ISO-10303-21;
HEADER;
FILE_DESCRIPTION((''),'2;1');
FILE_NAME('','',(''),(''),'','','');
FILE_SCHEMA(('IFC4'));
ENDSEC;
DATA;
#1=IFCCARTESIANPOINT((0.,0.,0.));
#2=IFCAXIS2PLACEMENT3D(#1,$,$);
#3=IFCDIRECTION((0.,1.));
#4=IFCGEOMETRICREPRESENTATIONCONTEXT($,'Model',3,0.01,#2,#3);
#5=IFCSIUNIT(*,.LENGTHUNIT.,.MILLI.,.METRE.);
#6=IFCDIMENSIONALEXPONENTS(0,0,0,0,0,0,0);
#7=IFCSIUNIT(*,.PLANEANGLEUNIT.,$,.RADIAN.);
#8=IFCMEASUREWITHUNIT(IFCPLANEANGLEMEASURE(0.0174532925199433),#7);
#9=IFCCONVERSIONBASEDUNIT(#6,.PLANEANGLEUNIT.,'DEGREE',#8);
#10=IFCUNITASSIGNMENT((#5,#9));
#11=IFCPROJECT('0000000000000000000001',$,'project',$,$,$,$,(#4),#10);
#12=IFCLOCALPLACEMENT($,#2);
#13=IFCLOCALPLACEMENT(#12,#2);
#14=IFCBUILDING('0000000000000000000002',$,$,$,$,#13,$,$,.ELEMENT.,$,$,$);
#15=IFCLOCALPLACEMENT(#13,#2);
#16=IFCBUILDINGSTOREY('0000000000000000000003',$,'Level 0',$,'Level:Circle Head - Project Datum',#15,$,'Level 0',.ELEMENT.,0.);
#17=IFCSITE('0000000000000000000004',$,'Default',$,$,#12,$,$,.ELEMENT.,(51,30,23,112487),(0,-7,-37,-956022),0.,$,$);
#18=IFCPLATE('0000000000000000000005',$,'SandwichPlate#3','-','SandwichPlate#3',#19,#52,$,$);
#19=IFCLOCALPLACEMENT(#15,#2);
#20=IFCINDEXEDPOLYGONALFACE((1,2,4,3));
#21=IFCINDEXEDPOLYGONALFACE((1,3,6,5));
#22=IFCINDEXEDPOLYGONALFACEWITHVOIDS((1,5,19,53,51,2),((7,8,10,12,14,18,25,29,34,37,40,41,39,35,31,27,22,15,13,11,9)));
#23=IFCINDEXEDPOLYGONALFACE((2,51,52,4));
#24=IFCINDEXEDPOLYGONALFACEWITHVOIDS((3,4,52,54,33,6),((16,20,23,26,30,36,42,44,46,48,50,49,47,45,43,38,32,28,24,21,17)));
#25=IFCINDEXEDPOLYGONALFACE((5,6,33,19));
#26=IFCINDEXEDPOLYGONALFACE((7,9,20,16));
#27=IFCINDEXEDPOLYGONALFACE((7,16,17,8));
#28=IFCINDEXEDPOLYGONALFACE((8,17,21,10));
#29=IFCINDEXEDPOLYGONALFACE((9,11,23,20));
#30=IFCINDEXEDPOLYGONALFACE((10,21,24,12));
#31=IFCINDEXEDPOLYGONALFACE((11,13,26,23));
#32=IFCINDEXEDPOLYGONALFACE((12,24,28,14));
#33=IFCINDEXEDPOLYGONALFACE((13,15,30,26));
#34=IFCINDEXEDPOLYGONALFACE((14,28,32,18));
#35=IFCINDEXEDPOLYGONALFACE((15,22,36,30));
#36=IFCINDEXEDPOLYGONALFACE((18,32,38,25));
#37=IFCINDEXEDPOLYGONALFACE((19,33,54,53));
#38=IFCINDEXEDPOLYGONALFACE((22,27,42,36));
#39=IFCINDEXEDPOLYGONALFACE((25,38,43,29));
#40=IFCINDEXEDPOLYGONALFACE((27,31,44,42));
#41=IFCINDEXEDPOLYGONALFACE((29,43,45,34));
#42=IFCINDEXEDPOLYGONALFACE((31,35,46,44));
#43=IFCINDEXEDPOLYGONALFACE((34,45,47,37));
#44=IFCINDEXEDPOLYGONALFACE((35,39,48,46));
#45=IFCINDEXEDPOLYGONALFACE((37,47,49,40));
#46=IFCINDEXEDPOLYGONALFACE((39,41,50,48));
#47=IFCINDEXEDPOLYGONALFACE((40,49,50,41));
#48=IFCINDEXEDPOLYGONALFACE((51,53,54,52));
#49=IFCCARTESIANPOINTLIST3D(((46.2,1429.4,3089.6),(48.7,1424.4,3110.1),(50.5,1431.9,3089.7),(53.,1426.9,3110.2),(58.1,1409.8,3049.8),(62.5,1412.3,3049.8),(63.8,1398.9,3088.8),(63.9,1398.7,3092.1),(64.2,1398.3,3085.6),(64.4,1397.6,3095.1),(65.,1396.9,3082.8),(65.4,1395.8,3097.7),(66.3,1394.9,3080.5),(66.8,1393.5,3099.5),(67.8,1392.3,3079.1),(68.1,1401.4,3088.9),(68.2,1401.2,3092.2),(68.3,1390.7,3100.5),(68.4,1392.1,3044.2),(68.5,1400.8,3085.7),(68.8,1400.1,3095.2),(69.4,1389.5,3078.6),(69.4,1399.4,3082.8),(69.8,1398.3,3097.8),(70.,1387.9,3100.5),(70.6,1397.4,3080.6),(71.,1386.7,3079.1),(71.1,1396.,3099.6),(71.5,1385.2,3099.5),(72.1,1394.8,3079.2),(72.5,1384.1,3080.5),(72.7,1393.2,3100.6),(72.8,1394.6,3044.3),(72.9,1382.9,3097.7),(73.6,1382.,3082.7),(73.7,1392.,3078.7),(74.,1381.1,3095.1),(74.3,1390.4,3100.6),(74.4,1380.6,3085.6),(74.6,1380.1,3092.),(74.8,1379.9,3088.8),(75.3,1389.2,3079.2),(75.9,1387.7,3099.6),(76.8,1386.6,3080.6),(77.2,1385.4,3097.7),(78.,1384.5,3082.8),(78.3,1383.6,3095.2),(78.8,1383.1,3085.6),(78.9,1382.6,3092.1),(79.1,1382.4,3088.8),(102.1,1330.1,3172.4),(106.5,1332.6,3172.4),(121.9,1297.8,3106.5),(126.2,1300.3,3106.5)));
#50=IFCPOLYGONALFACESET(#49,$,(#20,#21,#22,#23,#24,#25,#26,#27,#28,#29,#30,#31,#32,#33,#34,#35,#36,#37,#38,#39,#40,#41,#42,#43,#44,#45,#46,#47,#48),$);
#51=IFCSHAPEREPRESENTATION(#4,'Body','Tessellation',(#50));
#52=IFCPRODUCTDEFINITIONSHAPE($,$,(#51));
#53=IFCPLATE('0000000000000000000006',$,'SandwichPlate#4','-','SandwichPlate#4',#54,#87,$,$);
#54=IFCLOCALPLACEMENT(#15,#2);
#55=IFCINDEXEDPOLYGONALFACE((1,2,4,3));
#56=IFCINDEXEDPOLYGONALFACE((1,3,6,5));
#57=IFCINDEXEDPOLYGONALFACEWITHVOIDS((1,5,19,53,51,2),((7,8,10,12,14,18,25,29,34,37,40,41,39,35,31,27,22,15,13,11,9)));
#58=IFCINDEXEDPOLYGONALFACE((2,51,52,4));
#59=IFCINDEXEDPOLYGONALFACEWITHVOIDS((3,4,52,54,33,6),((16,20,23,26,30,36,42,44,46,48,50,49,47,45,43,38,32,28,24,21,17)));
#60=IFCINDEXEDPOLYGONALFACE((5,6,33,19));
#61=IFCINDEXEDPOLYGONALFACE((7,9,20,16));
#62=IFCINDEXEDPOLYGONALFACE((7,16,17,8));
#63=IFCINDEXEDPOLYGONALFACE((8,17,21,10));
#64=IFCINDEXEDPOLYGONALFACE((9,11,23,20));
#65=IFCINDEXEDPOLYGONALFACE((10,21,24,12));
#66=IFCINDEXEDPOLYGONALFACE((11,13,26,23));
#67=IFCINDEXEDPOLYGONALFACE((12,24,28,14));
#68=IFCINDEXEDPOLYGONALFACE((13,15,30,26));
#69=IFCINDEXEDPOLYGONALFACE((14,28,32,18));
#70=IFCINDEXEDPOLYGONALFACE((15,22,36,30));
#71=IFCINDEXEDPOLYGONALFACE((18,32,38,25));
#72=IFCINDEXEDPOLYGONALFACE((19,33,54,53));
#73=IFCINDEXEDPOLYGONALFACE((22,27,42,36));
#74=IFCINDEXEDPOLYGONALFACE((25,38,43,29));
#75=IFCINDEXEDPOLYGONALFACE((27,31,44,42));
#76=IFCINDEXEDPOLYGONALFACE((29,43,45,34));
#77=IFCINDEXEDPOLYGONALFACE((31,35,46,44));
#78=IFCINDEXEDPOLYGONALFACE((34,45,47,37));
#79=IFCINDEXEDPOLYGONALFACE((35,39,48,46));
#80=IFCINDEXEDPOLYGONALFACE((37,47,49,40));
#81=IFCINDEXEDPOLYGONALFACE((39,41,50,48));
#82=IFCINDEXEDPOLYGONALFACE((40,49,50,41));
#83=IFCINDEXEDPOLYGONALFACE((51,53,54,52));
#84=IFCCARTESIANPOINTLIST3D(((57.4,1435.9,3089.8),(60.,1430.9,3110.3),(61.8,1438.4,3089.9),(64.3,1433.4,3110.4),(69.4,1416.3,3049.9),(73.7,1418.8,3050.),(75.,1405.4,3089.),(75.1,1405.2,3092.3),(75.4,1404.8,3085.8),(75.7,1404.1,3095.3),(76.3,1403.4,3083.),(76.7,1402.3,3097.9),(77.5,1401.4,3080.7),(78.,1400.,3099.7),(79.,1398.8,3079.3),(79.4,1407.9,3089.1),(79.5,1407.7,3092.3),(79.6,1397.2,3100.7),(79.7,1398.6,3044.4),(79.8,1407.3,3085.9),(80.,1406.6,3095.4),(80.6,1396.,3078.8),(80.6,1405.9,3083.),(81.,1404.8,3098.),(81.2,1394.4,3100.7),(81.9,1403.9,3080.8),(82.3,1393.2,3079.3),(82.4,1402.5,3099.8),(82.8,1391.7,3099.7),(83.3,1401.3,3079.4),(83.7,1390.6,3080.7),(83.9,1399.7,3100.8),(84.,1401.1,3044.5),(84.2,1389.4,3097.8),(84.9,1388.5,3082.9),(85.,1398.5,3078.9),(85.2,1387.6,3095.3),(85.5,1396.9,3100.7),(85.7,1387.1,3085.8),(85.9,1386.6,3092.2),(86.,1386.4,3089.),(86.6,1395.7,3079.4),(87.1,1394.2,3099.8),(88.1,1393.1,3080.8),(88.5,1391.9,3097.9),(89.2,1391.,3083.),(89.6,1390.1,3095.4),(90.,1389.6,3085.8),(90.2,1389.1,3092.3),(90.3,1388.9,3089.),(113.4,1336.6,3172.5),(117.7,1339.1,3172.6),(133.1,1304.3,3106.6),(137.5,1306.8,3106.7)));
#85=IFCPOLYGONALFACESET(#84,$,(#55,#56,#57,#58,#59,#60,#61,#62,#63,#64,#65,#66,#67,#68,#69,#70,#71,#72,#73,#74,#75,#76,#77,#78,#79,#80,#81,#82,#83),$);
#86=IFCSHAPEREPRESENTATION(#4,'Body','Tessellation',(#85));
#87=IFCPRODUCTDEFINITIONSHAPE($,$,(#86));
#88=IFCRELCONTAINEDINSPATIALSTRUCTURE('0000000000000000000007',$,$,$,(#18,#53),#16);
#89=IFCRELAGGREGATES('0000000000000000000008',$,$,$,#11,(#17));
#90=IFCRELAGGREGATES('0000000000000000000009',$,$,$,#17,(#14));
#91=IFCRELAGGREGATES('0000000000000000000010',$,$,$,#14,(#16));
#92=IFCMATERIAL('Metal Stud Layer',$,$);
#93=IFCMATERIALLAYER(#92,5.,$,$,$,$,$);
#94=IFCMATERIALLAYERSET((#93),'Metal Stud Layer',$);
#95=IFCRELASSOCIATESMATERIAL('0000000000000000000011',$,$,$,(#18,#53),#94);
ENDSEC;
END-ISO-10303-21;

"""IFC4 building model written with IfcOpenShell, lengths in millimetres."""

from ifc_helpers import new_model, entity, si_unit, converted_unit, direction, frame, origin, origin_with_axes, origin_2d_with_axis, place, context, project, spatial, polyline, circle, outline, extrude, material, layer, layer_set, element, save


model = new_model("IFC4")

# Units and contexts
model_context = context("Model", 3, precision=0.01, world=origin(), true_north=direction((0.0, 1.0)))
ifc_project = project(units=[si_unit("LENGTHUNIT", "METRE", prefix="MILLI"), converted_unit("PLANEANGLEUNIT", "DEGREE", entity("IfcPlaneAngleMeasure", 0.0174532925199433), si_unit("PLANEANGLEUNIT", "RADIAN"), dimensions=[0, 0, 0, 0, 0, 0, 0])], contexts=[model_context])

# Site, building, storey
site_placement = place(None, origin())
site = spatial("IfcSite", under=ifc_project, at=site_placement, Name="Default", CompositionType="ELEMENT", RefLatitude=(51, 30, 23, 112487), RefLongitude=(0, -7, -37, -956022), RefElevation=0.0)
building_placement = place(site_placement, origin())
building = spatial("IfcBuilding", under=site, at=building_placement, CompositionType="ELEMENT")
storey_placement = place(building_placement, origin())
storey = spatial("IfcBuildingStorey", under=building, at=storey_placement, Name="Level 0", ObjectType="Level:Circle Head - Project Datum", LongName="Level 0", CompositionType="ELEMENT", Elevation=0.0)

# Plates, openings
ifc_material_1 = material(Name="Metal Stud Layer")
ifc_layer_1 = layer(ifc_material_1, 5.0)
ifc_layer_set_1 = layer_set([ifc_layer_1], Name="Metal Stud Layer")
plate_1_placement = place(storey_placement, frame((62.0, 1403.5, 3036.7), z_axis=(0.865935, 0.499948, 0.014432), x_axis=(-0.259821, 0.424992, 0.867107)))
plate_1 = element("IfcPlate", 1, at=plate_1_placement, inside=storey, material=ifc_layer_set_1, Name="SandwichPlate#3", Description="-", ObjectType="SandwichPlate#3", context=model_context, shape_type="SweptSolid", body=[
    extrude(outline(polyline([(0.0, 0.0), (76.0, 0.0), (76.0, 140.0), (0.0, 140.0), (0.0, 0.0)])), origin_with_axes(), (0.0, 0.0, 1.0), 5.0),
])
opening_1_placement = place(plate_1_placement, frame((0.0, 0.0, 0.0), z_axis=(0.0, 0.0, 1.0), x_axis=(1.0, 0.0, 0.0)))
element("IfcOpeningElement", 2, at=opening_1_placement, cuts=plate_1, ObjectType="Opening", context=model_context, shape_type="SweptSolid", body=[
    extrude(outline(polyline([(0.0, 0.0), (15.0, 0.0), (0.0, 15.0), (0.0, 0.0)])), origin(), (0.0, 0.0, 1.0), 5.0),
])
opening_2_placement = place(plate_1_placement, frame((0.0, 0.0, 0.0), z_axis=(0.0, 0.0, 1.0), x_axis=(1.0, 0.0, 0.0)))
element("IfcOpeningElement", 3, at=opening_2_placement, cuts=plate_1, ObjectType="Opening", context=model_context, shape_type="SweptSolid", body=[
    extrude(outline(polyline([(76.0, 0.0), (76.0, 15.0), (61.0, 0.0), (76.0, 0.0)])), origin(), (0.0, 0.0, 1.0), 5.0),
])
opening_3_placement = place(plate_1_placement, frame((38.0, 40.0, -0.5), z_axis=(0.0, 0.0, 1.0), x_axis=(0.0, 1.0, 0.0)))
element("IfcOpeningElement", 4, at=opening_3_placement, cuts=plate_1, ObjectType="Opening", context=model_context, shape_type="SweptSolid", body=[
    extrude(circle(Radius=11.0, at=origin_2d_with_axis()), origin(), (0.0, 0.0, 1.0), 6.0),
])
plate_2_placement = place(storey_placement, frame((73.3, 1410.0, 3036.9), z_axis=(0.865935, 0.499948, 0.014432), x_axis=(-0.259821, 0.424992, 0.867107)))
plate_2 = element("IfcPlate", 5, at=plate_2_placement, inside=storey, material=ifc_layer_set_1, Name="SandwichPlate#4", Description="-", ObjectType="SandwichPlate#4", context=model_context, shape_type="SweptSolid", body=[
    extrude(outline(polyline([(0.0, 0.0), (76.0, 0.0), (76.0, 140.0), (0.0, 140.0), (0.0, 0.0)])), origin_with_axes(), (0.0, 0.0, 1.0), 5.0),
])
opening_4_placement = place(plate_2_placement, frame((0.0, 0.0, 0.0), z_axis=(0.0, 0.0, 1.0), x_axis=(1.0, 0.0, 0.0)))
element("IfcOpeningElement", 6, at=opening_4_placement, cuts=plate_2, ObjectType="Opening", context=model_context, shape_type="SweptSolid", body=[
    extrude(outline(polyline([(0.0, 0.0), (15.0, 0.0), (0.0, 15.0), (0.0, 0.0)])), origin(), (0.0, 0.0, 1.0), 5.0),
])
opening_5_placement = place(plate_2_placement, frame((0.0, 0.0, 0.0), z_axis=(0.0, 0.0, 1.0), x_axis=(1.0, 0.0, 0.0)))
element("IfcOpeningElement", 7, at=opening_5_placement, cuts=plate_2, ObjectType="Opening", context=model_context, shape_type="SweptSolid", body=[
    extrude(outline(polyline([(76.0, 0.0), (76.0, 15.0), (61.0, 0.0), (76.0, 0.0)])), origin(), (0.0, 0.0, 1.0), 5.0),
])
opening_6_placement = place(plate_2_placement, frame((38.0, 40.0, -0.5), z_axis=(0.0, 0.0, 1.0), x_axis=(0.0, 1.0, 0.0)))
element("IfcOpeningElement", 8, at=opening_6_placement, cuts=plate_2, ObjectType="Opening", context=model_context, shape_type="SweptSolid", body=[
    extrude(circle(Radius=11.0, at=origin_2d_with_axis()), origin(), (0.0, 0.0, 1.0), 6.0),
])

save(model, "model.ifc")
